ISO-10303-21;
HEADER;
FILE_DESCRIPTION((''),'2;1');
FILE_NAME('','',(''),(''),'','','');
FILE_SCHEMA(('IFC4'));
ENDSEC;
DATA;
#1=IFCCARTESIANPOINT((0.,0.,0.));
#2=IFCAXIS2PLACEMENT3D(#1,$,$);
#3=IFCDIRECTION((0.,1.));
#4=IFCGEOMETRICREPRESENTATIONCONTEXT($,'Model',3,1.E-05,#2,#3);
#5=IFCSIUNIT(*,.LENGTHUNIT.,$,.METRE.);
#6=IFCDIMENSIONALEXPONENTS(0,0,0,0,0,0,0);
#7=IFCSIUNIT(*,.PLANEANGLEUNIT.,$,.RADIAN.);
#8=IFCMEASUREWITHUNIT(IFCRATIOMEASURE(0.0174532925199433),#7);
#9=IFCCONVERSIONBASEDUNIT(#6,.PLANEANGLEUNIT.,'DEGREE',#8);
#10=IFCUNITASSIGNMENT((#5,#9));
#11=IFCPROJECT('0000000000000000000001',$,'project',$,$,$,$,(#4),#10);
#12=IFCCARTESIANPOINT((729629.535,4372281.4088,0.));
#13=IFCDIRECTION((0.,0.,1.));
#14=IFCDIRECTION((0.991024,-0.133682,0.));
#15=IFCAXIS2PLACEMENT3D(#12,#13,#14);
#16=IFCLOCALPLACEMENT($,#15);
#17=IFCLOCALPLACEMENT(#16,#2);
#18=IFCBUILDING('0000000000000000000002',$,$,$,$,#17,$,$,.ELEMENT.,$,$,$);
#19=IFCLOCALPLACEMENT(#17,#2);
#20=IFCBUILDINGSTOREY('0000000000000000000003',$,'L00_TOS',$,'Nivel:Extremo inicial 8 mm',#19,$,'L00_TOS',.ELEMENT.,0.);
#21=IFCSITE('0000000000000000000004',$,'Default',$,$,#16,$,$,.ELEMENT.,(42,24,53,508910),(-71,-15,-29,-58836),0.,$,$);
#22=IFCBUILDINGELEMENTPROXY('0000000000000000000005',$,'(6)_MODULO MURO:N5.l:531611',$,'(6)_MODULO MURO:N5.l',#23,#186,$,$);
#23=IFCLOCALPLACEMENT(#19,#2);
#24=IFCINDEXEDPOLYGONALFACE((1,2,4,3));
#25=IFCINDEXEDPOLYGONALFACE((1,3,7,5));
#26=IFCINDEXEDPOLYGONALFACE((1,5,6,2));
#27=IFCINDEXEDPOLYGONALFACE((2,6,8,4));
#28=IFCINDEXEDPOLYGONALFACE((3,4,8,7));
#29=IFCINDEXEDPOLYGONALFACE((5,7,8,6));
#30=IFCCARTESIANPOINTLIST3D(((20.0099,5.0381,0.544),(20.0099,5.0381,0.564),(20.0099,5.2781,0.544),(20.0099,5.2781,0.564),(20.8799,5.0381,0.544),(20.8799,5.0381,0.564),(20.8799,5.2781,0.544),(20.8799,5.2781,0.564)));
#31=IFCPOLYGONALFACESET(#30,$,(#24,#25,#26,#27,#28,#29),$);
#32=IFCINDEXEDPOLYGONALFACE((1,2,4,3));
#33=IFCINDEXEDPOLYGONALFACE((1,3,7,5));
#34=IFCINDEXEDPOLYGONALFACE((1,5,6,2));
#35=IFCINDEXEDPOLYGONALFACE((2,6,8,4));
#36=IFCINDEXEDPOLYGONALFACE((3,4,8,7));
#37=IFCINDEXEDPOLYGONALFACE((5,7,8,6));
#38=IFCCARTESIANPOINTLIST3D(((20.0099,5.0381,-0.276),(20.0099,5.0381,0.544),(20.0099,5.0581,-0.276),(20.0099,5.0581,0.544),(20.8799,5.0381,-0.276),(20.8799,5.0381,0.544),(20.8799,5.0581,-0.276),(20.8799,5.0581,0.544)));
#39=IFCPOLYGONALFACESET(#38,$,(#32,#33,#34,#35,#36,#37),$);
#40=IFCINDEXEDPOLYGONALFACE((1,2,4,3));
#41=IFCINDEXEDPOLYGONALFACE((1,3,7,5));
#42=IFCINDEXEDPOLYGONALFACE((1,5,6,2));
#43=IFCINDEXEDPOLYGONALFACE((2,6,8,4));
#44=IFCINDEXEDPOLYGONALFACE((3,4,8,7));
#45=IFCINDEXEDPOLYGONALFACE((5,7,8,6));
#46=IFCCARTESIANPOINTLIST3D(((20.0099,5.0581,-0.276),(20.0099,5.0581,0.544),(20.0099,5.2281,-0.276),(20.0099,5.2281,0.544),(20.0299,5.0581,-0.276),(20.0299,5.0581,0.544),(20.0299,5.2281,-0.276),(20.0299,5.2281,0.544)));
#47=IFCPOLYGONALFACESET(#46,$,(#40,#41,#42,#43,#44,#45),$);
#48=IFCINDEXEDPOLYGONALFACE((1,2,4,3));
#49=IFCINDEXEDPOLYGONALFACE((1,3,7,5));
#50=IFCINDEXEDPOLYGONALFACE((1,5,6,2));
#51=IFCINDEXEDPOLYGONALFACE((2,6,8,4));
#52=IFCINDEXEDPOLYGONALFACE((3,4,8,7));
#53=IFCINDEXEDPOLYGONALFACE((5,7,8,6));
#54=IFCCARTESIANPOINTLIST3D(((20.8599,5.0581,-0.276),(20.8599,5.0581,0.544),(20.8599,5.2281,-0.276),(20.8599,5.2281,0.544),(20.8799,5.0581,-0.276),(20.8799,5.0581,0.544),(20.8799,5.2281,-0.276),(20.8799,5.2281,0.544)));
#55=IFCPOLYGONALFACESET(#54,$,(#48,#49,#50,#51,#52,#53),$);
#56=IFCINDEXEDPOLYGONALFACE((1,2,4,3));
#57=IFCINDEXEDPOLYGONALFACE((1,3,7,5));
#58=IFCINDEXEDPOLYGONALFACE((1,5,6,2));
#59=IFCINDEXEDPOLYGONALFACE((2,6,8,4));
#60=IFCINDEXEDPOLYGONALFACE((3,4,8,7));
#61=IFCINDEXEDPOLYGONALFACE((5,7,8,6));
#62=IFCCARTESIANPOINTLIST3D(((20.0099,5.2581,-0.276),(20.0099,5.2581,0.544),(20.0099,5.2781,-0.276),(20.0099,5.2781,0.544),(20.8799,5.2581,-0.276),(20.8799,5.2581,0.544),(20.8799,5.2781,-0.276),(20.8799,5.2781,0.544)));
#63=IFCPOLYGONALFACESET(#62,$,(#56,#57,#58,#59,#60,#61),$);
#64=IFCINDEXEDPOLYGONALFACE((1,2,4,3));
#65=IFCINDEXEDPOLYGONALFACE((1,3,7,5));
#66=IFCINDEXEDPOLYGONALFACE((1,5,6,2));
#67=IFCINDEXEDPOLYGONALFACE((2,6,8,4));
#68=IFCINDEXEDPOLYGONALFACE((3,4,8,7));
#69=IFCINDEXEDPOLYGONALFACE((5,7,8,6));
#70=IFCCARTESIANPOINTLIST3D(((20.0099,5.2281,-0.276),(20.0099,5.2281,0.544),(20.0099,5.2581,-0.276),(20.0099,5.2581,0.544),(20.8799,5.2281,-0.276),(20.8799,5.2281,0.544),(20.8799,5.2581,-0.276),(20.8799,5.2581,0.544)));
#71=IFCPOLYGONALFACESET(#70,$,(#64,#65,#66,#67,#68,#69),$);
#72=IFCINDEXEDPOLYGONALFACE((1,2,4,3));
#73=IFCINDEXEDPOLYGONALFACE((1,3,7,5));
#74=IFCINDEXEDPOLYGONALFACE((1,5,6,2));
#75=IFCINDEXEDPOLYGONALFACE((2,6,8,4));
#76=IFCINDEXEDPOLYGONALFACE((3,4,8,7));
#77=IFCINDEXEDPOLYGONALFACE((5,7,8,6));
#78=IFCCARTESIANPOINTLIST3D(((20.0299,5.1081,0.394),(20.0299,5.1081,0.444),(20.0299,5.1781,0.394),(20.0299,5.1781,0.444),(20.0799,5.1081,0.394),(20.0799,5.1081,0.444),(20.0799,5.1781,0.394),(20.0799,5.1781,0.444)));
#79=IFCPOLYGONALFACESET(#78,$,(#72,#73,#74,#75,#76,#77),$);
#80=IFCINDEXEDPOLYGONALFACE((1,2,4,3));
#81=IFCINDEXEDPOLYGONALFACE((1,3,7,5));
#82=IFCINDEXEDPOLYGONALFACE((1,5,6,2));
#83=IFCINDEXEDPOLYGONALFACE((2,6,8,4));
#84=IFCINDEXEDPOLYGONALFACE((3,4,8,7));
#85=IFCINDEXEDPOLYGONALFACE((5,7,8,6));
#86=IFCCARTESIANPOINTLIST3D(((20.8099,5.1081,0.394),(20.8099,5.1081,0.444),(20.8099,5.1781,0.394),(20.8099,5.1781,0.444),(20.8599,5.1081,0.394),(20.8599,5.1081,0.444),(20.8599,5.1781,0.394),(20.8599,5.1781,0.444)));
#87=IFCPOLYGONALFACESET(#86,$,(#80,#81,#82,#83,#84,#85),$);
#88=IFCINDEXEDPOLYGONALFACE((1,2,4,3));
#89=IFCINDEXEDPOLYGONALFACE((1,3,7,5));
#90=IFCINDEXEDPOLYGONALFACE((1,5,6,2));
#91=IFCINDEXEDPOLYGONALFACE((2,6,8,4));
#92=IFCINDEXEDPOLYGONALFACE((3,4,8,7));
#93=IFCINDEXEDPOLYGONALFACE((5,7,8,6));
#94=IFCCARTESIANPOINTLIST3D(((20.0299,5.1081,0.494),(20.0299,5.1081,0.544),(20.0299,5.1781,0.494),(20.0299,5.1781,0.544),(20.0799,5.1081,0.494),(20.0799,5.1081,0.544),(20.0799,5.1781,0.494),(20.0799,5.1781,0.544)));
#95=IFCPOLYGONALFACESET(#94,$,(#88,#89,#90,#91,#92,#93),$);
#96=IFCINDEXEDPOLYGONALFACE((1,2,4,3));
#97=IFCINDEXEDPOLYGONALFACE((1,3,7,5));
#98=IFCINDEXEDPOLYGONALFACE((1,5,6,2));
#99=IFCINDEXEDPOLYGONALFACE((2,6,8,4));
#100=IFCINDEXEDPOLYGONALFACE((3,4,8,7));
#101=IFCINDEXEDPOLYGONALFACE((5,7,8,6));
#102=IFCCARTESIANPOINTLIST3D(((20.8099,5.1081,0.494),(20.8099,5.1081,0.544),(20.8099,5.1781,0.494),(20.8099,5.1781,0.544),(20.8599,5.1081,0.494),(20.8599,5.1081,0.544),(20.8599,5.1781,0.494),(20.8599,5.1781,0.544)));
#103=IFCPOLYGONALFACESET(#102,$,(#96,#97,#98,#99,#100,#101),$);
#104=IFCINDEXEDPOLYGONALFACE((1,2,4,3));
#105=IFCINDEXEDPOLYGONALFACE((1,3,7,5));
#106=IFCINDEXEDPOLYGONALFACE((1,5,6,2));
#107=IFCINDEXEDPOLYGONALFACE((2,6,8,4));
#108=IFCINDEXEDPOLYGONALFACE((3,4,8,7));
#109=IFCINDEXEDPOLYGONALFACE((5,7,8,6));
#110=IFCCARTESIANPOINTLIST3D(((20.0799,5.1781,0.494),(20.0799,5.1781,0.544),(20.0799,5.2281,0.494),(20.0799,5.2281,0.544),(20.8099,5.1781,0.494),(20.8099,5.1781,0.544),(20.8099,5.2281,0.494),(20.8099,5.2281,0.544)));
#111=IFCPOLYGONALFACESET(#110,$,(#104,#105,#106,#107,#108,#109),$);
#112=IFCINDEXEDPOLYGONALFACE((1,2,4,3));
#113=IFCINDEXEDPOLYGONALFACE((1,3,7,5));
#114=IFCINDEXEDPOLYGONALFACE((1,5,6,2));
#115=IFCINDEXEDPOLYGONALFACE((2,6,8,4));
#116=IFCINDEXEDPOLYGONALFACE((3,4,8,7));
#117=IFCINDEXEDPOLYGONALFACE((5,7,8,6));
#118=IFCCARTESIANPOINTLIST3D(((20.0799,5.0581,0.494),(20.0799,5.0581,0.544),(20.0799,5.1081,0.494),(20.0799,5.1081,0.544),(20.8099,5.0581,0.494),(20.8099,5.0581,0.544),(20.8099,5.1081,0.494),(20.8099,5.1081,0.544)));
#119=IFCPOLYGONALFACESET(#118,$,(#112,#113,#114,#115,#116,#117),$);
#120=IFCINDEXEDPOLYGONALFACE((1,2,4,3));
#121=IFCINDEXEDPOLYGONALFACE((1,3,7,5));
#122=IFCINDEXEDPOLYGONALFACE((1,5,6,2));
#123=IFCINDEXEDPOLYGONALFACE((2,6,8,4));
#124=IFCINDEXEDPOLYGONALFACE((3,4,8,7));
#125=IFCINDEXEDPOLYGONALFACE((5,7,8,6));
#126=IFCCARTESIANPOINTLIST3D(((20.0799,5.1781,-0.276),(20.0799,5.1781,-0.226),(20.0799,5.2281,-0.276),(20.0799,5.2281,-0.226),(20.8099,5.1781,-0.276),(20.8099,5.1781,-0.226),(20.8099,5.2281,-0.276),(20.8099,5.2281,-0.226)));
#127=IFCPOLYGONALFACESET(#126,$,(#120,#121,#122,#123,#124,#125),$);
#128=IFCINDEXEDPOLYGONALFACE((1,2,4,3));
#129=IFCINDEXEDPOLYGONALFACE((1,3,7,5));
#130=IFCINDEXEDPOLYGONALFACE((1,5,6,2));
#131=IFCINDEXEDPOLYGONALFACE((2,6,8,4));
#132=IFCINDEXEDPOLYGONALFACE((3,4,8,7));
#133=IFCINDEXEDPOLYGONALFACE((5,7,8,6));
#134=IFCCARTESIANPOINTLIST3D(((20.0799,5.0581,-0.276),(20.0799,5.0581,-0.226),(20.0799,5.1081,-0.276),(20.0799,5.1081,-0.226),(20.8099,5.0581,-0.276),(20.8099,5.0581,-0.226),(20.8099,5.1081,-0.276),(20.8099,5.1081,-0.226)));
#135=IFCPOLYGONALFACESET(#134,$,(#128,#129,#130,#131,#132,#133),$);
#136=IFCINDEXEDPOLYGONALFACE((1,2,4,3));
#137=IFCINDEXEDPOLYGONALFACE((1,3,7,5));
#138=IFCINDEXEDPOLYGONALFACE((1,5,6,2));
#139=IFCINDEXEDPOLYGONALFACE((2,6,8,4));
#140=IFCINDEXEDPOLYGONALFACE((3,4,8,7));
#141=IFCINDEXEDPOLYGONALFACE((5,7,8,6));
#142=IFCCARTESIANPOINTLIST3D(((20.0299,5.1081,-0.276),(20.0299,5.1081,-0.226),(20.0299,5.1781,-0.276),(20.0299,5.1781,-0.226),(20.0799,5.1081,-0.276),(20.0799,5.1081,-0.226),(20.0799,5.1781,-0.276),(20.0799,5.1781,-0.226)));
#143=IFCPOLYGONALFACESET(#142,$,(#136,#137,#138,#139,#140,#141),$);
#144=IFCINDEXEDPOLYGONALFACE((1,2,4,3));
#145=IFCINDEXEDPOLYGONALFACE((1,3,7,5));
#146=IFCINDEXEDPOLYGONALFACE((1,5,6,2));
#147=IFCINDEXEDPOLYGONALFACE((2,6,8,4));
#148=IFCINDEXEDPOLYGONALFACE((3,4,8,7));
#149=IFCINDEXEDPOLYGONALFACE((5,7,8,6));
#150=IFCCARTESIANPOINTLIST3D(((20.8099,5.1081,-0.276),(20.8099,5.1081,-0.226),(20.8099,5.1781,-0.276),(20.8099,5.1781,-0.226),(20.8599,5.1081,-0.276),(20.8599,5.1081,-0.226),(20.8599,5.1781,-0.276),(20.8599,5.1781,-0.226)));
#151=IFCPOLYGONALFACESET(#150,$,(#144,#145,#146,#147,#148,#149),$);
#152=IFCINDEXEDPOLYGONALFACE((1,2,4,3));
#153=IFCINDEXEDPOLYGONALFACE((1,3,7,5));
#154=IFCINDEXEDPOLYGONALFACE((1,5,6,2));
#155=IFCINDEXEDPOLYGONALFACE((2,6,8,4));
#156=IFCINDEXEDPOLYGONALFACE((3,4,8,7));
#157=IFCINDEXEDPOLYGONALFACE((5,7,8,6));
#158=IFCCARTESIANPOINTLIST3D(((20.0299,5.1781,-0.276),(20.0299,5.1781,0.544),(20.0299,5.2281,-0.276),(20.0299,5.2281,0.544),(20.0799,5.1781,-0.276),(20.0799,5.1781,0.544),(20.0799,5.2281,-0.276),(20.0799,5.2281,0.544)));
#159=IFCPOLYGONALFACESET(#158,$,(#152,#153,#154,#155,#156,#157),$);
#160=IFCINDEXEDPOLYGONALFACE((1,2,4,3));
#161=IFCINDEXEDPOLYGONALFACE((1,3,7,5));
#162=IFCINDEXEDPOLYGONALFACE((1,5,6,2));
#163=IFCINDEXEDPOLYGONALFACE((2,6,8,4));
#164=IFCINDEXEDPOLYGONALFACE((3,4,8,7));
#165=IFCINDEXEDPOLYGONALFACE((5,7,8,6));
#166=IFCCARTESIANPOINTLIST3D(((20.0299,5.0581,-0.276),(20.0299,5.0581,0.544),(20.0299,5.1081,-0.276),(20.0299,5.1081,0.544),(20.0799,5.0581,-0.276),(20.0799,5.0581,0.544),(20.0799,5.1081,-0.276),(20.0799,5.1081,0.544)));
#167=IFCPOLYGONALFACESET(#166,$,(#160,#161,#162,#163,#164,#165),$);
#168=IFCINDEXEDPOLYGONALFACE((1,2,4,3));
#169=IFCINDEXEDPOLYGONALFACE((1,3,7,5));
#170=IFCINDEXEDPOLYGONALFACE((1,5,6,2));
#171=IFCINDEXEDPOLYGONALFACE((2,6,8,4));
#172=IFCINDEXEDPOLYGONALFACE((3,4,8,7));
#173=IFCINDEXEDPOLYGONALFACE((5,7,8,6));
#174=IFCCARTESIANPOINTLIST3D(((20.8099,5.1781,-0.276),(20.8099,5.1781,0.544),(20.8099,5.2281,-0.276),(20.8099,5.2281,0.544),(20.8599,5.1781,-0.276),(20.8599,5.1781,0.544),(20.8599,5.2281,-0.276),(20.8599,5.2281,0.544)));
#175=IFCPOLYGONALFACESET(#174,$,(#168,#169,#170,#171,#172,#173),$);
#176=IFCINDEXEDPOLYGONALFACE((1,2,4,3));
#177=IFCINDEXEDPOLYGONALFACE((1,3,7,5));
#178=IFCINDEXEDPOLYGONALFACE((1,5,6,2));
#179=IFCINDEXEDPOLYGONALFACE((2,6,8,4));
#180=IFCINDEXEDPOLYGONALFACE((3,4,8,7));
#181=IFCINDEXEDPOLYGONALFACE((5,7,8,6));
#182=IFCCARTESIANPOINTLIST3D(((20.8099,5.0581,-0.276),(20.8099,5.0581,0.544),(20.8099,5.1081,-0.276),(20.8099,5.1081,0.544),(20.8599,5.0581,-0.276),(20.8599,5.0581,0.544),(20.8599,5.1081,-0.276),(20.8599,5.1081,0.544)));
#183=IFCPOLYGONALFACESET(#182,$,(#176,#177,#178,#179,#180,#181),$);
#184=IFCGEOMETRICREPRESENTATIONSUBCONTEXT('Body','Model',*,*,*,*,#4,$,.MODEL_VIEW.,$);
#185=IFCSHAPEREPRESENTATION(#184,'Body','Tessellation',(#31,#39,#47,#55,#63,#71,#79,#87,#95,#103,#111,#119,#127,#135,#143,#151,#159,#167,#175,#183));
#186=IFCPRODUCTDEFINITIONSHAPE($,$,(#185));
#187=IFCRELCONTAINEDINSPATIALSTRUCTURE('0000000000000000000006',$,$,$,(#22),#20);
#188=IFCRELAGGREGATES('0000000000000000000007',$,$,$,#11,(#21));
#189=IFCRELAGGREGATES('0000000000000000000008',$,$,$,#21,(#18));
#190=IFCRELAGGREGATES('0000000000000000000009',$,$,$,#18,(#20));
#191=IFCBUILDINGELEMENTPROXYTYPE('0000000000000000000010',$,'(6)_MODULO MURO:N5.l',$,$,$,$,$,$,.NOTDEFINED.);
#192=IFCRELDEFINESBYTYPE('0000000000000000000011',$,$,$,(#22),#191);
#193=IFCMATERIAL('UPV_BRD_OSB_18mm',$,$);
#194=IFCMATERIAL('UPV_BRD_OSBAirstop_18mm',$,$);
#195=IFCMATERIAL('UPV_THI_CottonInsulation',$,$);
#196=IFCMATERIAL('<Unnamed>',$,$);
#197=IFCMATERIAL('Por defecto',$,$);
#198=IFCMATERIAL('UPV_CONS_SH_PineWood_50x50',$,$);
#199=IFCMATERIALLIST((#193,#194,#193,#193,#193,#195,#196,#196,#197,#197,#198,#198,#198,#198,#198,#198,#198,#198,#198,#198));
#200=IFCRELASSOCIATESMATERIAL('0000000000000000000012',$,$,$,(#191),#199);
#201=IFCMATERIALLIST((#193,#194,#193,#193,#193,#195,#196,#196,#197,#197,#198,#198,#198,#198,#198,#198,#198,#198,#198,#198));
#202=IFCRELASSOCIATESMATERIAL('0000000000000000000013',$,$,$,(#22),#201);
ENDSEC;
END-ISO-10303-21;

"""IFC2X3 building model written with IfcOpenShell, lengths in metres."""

from ifc_helpers import new_model, entity, si_unit, converted_unit, direction, frame, frame_2d, origin, origin_2d_with_axis, place, context, subcontext, project, spatial, rectangle, extrude, source, transform, mapped, material, material_list, type_object, type_shapes, element, save


model = new_model("IFC2X3")

# Units and contexts
model_context = context("Model", 3, precision=1e-05, world=origin(), true_north=direction((0.0, 1.0)))
body_context = subcontext(model_context, "Body", "Model", "MODEL_VIEW")
ifc_project = project(units=[si_unit("LENGTHUNIT", "METRE"), converted_unit("PLANEANGLEUNIT", "DEGREE", entity("IfcRatioMeasure", 0.0174532925199433), si_unit("PLANEANGLEUNIT", "RADIAN"), dimensions=[0, 0, 0, 0, 0, 0, 0])], contexts=[model_context])

# Site, building, storey
site_placement = place(None, frame((729629.535, 4372281.4088, 0.0), z_axis=(0.0, 0.0, 1.0), x_axis=(0.991024, -0.133682, 0.0)))
site = spatial("IfcSite", under=ifc_project, at=site_placement, Name="Default", CompositionType="ELEMENT", RefLatitude=(42, 24, 53, 508910), RefLongitude=(-71, -15, -29, -58836), RefElevation=0.0)
building_placement = place(site_placement, origin())
building = spatial("IfcBuilding", under=site, at=building_placement, CompositionType="ELEMENT")
storey_placement = place(building_placement, origin())
storey = spatial("IfcBuildingStorey", under=building, at=storey_placement, Name="L00_TOS", ObjectType="Nivel:Extremo inicial 8 mm", LongName="L00_TOS", CompositionType="ELEMENT", Elevation=0.0)

# Building element proxy
ifc_material_1 = material(Name="UPV_BRD_OSBAirstop_18mm")
ifc_material_2 = material(Name="UPV_BRD_OSB_18mm")
ifc_material_3 = material(Name="UPV_THI_CottonInsulation")
ifc_material_4 = material(Name="<Unnamed>")
ifc_material_5 = material(Name="UPV_CONS_SH_PineWood_50x50")
ifc_material_6 = material(Name="Por defecto")
ifc_material_list_1 = material_list([ifc_material_2, ifc_material_1, ifc_material_2, ifc_material_2, ifc_material_2, ifc_material_3, ifc_material_4, ifc_material_4, ifc_material_6, ifc_material_6, ifc_material_5, ifc_material_5, ifc_material_5, ifc_material_5, ifc_material_5, ifc_material_5, ifc_material_5, ifc_material_5, ifc_material_5, ifc_material_5])
ifc_material_list_2 = material_list([ifc_material_2, ifc_material_1, ifc_material_2, ifc_material_2, ifc_material_2, ifc_material_3, ifc_material_4, ifc_material_4, ifc_material_6, ifc_material_6, ifc_material_5, ifc_material_5, ifc_material_5, ifc_material_5, ifc_material_5, ifc_material_5, ifc_material_5, ifc_material_5, ifc_material_5, ifc_material_5])
building_element_proxy_type_1 = type_object("IfcBuildingElementProxyType", Name="(6)_MODULO MURO:N5.l", PredefinedType="NOTDEFINED", material=ifc_material_list_2)
shared_shape_1 = source(origin(), body_context, "Body", "SweptSolid", [
    extrude(rectangle(XDim=0.87, YDim=0.24, at=origin_2d_with_axis()), frame((0.0, 0.015, 0.82), z_axis=(0.0, 0.0, 1.0), x_axis=(-1.0, 0.0, 0.0)), (0.0, 0.0, 1.0), 0.02),
    extrude(rectangle(XDim=0.87, YDim=0.02, at=origin_2d_with_axis()), frame((0.0, -0.095, 0.0)), (0.0, 0.0, 1.0), 0.82),
    extrude(rectangle(XDim=0.17, YDim=0.02, at=frame_2d((0.0, 0.0), x_axis=(1.0, 0.0))), frame((-0.425, 0.0, 0.0), z_axis=(0.0, 0.0, 1.0), x_axis=(0.0, -1.0, 0.0)), (0.0, 0.0, 1.0), 0.82),
    extrude(rectangle(XDim=0.17, YDim=0.02, at=origin_2d_with_axis()), frame((0.425, 0.0, 0.0), z_axis=(0.0, 0.0, 1.0), x_axis=(0.0, -1.0, 0.0)), (0.0, 0.0, 1.0), 0.82),
    extrude(rectangle(XDim=0.87, YDim=0.02, at=origin_2d_with_axis()), frame((0.0, 0.125, 0.0), z_axis=(0.0, 0.0, 1.0), x_axis=(-1.0, 0.0, 0.0)), (0.0, 0.0, 1.0), 0.82),
    extrude(rectangle(XDim=0.87, YDim=0.03, at=origin_2d_with_axis()), frame((0.0, 0.1, 0.0), z_axis=(0.0, 0.0, 1.0), x_axis=(-1.0, 0.0, 0.0)), (0.0, 0.0, 1.0), 0.82),
    extrude(rectangle(XDim=0.07, YDim=0.05, at=origin_2d_with_axis()), frame((-0.39, 0.0, 0.67), z_axis=(0.0, 0.0, 1.0), x_axis=(0.0, 1.0, 0.0)), (0.0, 0.0, 1.0), 0.05),
    extrude(rectangle(XDim=0.07, YDim=0.05, at=origin_2d_with_axis()), frame((0.39, 0.0, 0.67), z_axis=(0.0, 0.0, 1.0), x_axis=(0.0, 1.0, 0.0)), (0.0, 0.0, 1.0), 0.05),
    extrude(rectangle(XDim=0.07, YDim=0.05, at=origin_2d_with_axis()), frame((-0.39, 0.0, 0.77), z_axis=(0.0, 0.0, 1.0), x_axis=(0.0, -1.0, 0.0)), (0.0, 0.0, 1.0), 0.05),
    extrude(rectangle(XDim=0.07, YDim=0.05, at=frame_2d((0.0, 0.0), x_axis=(1.0, 0.0))), frame((0.39, 0.0, 0.77), z_axis=(0.0, 0.0, 1.0), x_axis=(0.0, -1.0, 0.0)), (0.0, 0.0, 1.0), 0.05),
    extrude(rectangle(XDim=0.73, YDim=0.05, at=origin_2d_with_axis()), frame((0.0, 0.06, 0.77), z_axis=(0.0, 0.0, 1.0), x_axis=(-1.0, 0.0, 0.0)), (0.0, 0.0, 1.0), 0.05),
    extrude(rectangle(XDim=0.05, YDim=0.73, at=origin_2d_with_axis()), frame((0.0, -0.06, 0.77), z_axis=(0.0, 0.0, 1.0), x_axis=(0.0, -1.0, 0.0)), (0.0, 0.0, 1.0), 0.05),
    extrude(rectangle(XDim=0.05, YDim=0.73, at=origin_2d_with_axis()), frame((0.0, 0.06, 0.0), z_axis=(0.0, 0.0, 1.0), x_axis=(0.0, -1.0, 0.0)), (0.0, 0.0, 1.0), 0.05),
    extrude(rectangle(XDim=0.05, YDim=0.73, at=origin_2d_with_axis()), frame((0.0, -0.06, 0.0), z_axis=(0.0, 0.0, 1.0), x_axis=(0.0, -1.0, 0.0)), (0.0, 0.0, 1.0), 0.05),
    extrude(rectangle(XDim=0.07, YDim=0.05, at=origin_2d_with_axis()), frame((-0.39, 0.0, 0.0), z_axis=(0.0, 0.0, 1.0), x_axis=(0.0, -1.0, 0.0)), (0.0, 0.0, 1.0), 0.05),
    extrude(rectangle(XDim=0.05, YDim=0.07, at=origin_2d_with_axis()), frame((0.39, 0.0, 0.0), z_axis=(0.0, 0.0, 1.0), x_axis=(-1.0, 0.0, 0.0)), (0.0, 0.0, 1.0), 0.05),
    extrude(rectangle(XDim=0.05, YDim=0.05, at=origin_2d_with_axis()), frame((-0.39, 0.06, 0.0), z_axis=(0.0, 0.0, 1.0), x_axis=(0.0, -1.0, 0.0)), (0.0, 0.0, 1.0), 0.82),
    extrude(rectangle(XDim=0.05, YDim=0.05, at=origin_2d_with_axis()), frame((-0.39, -0.06, 0.0), z_axis=(0.0, 0.0, 1.0), x_axis=(0.0, -1.0, 0.0)), (0.0, 0.0, 1.0), 0.82),
    extrude(rectangle(XDim=0.05, YDim=0.05, at=origin_2d_with_axis()), frame((0.39, 0.06, 0.0), z_axis=(0.0, 0.0, 1.0), x_axis=(0.0, -1.0, 0.0)), (0.0, 0.0, 1.0), 0.82),
    extrude(rectangle(XDim=0.05, YDim=0.05, at=origin_2d_with_axis()), frame((0.39, -0.06, 0.0), z_axis=(0.0, 0.0, 1.0), x_axis=(0.0, -1.0, 0.0)), (0.0, 0.0, 1.0), 0.82),
])
type_shapes(building_element_proxy_type_1, [shared_shape_1])
proxy_1_placement = place(storey_placement, frame((20.4449, 5.1431, -0.276)))
element("IfcBuildingElementProxy", 1, at=proxy_1_placement, inside=storey, type_object=building_element_proxy_type_1, material=ifc_material_list_1, Name="(6)_MODULO MURO:N5.l:531611", ObjectType="(6)_MODULO MURO:N5.l", context=body_context, shape_type="MappedRepresentation", body=[
    mapped(shared_shape_1, transform((0.0, 0.0, 0.0), scale=1.0)),
])

save(model, "model.ifc")
